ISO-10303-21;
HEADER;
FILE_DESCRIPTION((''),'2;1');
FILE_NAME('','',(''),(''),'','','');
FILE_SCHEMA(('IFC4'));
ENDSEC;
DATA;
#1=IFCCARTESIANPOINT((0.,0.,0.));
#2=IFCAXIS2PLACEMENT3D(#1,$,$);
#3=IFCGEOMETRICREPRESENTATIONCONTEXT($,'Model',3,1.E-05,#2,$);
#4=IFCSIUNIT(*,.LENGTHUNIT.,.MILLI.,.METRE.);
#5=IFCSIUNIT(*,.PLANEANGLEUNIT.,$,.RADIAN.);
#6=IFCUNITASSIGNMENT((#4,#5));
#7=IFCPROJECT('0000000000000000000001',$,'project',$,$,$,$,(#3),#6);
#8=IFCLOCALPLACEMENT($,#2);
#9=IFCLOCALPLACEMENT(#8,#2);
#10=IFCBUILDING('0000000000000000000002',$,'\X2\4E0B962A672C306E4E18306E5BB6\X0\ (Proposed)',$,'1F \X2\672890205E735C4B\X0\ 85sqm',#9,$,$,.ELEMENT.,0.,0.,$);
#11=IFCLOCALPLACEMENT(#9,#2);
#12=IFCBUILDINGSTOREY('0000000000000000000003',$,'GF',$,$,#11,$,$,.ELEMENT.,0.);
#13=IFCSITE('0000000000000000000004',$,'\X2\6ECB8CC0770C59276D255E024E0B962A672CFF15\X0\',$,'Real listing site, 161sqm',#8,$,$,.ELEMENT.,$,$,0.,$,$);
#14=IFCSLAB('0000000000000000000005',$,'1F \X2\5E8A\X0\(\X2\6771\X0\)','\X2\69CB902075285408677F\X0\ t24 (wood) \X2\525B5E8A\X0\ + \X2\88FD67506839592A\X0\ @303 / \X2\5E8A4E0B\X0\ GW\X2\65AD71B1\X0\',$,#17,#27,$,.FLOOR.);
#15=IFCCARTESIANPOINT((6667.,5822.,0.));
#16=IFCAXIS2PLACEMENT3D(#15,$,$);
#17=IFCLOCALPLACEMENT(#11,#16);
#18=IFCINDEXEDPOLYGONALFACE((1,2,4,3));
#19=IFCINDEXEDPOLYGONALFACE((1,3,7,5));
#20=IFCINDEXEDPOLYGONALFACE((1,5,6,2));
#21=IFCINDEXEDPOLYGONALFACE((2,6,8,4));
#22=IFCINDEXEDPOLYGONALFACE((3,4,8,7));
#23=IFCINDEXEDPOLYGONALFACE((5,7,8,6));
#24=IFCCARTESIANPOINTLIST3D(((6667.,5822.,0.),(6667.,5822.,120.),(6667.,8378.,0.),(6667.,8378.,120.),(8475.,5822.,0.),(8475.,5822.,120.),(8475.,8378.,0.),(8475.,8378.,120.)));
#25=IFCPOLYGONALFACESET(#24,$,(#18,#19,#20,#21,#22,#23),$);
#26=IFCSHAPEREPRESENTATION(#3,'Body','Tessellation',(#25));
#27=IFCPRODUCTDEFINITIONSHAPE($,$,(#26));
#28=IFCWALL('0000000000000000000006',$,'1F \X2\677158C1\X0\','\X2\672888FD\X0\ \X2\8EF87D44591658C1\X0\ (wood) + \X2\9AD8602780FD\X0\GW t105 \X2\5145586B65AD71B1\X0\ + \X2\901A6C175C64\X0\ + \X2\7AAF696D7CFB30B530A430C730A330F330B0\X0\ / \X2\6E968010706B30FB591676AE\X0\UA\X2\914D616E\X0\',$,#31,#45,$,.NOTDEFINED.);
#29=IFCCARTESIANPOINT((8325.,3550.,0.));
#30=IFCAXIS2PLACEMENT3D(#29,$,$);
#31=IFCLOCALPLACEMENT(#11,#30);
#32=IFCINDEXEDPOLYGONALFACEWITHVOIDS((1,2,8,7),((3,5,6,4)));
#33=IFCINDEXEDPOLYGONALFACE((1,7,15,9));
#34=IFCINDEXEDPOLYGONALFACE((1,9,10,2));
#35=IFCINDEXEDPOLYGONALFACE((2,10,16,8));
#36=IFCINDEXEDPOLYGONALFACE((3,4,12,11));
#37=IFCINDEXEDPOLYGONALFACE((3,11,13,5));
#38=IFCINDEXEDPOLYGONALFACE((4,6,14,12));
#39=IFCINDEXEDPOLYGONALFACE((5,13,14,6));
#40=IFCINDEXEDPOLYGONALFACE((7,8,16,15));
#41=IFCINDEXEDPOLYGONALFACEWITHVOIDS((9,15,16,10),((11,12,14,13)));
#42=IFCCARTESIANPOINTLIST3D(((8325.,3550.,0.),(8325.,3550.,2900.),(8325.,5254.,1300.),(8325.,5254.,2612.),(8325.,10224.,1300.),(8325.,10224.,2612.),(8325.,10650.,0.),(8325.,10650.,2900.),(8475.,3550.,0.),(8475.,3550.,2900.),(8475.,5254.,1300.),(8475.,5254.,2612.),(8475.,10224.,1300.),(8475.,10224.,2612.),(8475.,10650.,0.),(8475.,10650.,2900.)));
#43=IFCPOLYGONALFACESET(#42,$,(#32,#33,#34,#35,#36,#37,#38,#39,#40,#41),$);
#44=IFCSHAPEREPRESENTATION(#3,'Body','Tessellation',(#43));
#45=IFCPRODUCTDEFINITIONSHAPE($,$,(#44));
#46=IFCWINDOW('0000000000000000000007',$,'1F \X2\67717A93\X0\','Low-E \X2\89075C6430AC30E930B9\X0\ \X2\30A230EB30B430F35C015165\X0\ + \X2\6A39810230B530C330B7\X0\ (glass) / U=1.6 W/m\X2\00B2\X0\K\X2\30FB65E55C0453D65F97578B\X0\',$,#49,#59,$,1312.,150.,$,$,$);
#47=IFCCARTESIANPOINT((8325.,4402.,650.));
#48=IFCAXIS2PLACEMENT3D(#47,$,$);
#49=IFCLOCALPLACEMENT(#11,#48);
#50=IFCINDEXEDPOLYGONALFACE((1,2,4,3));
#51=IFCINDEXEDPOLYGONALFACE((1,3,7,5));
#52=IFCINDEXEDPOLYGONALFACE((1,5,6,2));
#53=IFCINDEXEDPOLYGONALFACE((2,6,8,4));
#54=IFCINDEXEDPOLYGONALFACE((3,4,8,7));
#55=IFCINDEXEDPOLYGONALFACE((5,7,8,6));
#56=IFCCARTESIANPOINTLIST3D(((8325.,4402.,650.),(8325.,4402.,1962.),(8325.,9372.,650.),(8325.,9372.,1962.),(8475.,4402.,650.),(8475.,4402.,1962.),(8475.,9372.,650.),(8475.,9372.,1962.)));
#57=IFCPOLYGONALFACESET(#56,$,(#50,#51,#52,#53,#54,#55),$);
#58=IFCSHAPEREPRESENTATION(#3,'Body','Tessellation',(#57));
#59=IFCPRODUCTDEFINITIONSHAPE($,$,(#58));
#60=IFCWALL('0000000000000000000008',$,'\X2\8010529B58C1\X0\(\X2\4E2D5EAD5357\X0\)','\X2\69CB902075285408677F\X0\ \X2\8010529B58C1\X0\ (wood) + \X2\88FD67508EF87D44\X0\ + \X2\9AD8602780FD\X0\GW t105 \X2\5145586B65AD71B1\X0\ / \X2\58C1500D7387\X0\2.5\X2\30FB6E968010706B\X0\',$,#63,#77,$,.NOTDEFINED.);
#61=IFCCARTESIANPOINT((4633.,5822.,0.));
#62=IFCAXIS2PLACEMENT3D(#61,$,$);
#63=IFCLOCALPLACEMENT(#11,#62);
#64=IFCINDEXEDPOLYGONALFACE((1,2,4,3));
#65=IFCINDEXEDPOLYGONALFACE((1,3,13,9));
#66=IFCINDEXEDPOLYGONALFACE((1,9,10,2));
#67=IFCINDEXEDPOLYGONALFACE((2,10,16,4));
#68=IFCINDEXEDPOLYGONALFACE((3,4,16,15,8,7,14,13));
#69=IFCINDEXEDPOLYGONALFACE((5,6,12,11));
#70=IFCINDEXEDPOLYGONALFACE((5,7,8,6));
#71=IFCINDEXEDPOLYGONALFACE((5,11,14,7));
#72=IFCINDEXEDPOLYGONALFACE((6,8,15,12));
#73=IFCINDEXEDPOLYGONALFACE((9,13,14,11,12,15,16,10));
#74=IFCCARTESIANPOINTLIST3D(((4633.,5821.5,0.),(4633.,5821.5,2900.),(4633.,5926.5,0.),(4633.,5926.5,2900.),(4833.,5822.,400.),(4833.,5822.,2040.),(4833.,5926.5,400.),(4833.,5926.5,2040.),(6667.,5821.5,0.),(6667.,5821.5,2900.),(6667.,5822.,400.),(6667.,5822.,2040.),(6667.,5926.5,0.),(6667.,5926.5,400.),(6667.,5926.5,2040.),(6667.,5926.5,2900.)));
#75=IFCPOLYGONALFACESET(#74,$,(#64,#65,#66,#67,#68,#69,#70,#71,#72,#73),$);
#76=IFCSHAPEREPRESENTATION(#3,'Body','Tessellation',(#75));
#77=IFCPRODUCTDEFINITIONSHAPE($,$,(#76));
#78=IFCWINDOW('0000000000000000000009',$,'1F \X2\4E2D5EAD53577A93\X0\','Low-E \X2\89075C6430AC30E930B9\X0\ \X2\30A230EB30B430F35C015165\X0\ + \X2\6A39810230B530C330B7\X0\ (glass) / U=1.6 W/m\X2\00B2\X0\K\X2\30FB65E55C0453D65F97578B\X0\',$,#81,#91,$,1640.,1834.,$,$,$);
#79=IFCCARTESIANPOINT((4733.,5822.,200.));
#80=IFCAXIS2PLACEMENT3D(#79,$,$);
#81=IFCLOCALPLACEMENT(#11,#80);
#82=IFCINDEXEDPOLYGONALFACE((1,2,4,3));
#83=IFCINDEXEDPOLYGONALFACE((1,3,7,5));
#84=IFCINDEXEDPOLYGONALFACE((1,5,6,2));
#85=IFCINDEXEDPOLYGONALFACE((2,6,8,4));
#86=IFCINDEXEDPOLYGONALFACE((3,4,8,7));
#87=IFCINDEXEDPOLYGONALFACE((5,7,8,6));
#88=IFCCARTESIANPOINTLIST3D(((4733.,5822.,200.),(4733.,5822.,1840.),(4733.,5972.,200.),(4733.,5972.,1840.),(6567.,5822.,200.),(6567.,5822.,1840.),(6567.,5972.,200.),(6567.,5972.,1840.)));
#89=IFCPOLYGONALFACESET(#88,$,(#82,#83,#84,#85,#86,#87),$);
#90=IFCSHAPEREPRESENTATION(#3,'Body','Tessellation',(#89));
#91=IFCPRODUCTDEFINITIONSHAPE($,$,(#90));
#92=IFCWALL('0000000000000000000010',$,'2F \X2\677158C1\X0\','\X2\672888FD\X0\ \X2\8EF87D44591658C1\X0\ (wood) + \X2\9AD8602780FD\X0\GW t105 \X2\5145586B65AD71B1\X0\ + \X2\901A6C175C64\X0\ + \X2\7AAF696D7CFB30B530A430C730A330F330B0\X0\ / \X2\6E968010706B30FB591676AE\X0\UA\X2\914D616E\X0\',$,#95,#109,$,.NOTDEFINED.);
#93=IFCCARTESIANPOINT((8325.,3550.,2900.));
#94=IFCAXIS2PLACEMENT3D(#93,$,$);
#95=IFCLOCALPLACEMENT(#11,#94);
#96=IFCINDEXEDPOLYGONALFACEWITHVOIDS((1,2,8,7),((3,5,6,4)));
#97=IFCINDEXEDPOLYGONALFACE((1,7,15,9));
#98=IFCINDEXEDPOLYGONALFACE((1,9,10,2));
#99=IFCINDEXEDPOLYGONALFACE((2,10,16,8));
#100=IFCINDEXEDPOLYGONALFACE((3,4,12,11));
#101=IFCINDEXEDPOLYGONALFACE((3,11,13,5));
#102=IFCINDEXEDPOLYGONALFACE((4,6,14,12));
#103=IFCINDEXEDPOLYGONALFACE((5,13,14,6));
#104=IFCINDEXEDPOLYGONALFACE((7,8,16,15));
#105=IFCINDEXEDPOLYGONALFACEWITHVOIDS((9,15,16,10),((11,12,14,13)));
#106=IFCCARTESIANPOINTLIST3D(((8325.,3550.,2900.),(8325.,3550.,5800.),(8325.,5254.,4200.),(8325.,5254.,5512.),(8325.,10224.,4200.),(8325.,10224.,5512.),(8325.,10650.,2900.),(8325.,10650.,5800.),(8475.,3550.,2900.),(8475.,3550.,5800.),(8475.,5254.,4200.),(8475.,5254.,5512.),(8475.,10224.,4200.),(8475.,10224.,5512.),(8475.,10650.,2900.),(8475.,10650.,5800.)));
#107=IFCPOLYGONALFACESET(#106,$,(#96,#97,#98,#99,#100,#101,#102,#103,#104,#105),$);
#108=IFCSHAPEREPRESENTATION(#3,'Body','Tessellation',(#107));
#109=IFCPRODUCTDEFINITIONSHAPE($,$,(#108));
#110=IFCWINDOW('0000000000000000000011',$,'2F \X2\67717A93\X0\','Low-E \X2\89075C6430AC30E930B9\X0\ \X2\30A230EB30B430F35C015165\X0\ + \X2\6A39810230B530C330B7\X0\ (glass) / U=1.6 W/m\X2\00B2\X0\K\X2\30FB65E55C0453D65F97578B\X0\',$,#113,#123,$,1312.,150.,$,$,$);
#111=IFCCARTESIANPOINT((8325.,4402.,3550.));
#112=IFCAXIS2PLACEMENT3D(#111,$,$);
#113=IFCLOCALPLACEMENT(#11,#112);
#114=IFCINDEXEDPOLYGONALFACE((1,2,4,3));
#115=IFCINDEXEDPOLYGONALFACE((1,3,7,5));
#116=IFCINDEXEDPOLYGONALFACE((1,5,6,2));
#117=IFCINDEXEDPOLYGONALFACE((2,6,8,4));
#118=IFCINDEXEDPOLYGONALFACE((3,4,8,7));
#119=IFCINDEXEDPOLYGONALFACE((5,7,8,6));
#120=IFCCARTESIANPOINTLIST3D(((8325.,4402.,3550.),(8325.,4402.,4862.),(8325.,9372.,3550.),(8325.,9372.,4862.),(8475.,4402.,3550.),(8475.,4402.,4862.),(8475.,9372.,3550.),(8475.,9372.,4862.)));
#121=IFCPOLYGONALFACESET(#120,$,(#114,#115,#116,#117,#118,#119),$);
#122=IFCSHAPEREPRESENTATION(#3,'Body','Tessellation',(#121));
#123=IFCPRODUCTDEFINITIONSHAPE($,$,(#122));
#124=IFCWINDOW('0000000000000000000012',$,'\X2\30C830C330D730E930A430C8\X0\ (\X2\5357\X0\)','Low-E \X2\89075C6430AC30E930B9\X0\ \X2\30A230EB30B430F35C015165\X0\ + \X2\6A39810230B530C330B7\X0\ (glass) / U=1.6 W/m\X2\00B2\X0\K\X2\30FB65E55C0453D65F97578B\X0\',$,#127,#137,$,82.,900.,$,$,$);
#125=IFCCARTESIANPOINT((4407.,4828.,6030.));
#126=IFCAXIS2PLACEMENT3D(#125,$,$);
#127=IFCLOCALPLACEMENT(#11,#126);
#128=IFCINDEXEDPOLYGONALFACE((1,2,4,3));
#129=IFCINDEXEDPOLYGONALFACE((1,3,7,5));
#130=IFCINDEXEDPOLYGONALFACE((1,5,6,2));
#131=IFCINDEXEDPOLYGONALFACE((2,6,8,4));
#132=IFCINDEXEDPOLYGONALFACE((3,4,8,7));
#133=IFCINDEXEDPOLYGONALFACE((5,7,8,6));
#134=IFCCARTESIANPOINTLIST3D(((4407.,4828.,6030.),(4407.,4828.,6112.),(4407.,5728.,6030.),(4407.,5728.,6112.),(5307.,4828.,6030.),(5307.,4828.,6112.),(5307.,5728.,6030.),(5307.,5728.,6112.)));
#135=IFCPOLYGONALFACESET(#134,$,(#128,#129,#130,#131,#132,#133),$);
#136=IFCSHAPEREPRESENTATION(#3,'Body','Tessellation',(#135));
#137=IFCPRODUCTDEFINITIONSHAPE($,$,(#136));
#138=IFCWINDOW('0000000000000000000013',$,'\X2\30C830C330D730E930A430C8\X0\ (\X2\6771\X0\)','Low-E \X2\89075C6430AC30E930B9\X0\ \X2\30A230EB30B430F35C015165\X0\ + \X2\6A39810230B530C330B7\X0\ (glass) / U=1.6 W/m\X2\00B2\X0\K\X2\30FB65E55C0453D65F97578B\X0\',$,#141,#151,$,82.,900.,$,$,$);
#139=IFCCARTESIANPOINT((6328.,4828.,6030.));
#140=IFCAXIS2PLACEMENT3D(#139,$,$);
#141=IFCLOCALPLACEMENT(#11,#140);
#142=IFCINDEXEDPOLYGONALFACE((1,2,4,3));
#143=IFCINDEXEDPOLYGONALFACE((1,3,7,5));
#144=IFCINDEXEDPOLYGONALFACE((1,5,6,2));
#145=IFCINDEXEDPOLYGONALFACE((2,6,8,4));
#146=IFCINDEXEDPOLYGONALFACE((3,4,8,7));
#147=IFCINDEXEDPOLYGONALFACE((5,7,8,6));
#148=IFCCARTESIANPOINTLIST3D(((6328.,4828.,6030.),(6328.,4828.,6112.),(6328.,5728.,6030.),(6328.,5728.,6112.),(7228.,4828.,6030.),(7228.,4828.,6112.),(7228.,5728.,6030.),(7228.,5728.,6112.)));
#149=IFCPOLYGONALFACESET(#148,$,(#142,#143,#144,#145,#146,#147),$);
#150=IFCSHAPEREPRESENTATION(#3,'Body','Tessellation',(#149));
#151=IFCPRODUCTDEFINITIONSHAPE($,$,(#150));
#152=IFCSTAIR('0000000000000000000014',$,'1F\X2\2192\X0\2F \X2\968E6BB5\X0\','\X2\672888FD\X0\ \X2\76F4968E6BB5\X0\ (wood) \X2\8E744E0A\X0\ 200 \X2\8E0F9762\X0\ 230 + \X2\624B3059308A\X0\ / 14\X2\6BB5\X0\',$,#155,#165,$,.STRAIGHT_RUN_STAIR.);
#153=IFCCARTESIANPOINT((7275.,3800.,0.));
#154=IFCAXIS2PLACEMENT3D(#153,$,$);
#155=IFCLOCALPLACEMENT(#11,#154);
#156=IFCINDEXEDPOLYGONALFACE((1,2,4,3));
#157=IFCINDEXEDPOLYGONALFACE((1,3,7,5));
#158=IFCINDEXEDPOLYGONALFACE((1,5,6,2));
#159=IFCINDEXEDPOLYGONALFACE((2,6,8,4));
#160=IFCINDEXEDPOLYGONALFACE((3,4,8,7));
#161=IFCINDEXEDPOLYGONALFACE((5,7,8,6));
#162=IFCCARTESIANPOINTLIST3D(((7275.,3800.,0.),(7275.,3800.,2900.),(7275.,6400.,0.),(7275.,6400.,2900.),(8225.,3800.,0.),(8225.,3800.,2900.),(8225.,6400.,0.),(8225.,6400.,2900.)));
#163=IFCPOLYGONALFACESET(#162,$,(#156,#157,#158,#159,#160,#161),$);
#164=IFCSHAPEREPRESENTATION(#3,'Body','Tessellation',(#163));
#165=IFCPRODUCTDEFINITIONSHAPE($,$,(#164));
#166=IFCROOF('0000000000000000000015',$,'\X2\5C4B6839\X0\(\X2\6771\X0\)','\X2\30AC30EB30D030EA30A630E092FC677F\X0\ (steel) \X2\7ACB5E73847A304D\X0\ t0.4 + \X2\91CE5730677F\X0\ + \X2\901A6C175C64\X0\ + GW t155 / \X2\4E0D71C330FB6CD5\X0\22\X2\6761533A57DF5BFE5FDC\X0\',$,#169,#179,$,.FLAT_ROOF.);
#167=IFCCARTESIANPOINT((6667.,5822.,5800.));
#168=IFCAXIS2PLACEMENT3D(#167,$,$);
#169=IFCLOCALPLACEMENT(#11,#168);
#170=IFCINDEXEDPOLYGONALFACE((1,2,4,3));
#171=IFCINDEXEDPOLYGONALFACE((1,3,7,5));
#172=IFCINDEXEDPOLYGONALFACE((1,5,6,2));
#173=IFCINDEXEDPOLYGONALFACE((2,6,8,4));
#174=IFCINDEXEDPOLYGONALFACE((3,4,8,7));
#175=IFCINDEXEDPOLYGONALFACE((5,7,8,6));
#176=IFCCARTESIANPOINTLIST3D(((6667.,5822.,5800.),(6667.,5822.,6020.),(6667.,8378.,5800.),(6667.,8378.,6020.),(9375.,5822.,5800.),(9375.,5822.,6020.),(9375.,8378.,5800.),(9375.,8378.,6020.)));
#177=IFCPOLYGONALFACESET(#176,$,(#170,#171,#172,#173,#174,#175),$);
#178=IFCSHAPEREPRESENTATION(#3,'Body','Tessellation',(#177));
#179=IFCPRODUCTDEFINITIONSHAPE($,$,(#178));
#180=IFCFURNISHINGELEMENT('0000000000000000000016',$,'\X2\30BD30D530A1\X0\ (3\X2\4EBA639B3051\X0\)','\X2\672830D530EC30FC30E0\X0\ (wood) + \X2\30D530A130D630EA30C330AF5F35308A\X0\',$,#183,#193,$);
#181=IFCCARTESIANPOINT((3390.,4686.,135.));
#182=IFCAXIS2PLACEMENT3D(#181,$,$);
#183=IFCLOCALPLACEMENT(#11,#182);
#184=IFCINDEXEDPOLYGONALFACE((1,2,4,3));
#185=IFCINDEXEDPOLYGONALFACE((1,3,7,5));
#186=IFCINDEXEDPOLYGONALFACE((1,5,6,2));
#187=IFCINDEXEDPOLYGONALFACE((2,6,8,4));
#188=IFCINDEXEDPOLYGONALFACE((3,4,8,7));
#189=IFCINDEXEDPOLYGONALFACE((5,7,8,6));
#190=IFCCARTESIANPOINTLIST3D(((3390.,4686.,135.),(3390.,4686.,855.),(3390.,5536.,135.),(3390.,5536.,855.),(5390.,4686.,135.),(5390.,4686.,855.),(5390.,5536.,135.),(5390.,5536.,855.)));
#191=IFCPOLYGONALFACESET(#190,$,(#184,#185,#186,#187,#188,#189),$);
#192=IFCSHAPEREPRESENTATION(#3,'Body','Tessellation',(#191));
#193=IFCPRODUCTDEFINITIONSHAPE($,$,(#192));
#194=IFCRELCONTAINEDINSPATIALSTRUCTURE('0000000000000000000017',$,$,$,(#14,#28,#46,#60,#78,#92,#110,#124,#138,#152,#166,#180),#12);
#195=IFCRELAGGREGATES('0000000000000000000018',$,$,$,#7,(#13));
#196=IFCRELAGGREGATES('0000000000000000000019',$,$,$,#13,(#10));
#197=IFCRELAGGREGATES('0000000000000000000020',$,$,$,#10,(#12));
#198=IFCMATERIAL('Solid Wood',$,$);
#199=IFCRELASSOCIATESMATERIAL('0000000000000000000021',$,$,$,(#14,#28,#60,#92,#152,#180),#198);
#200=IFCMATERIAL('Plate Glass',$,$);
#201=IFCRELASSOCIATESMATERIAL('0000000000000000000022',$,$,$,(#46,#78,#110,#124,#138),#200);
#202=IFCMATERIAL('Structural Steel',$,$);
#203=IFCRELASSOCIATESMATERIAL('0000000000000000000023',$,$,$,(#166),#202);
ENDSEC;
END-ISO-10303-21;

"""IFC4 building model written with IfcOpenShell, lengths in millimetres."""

from ifc_helpers import new_model, si_unit, frame, frame_2d, origin, place, context, project, spatial, rectangle, extrude, material, element, fill, save


model = new_model("IFC4")

# Units and contexts
model_context = context("Model", 3, precision=1e-05, world=origin())
ifc_project = project(units=[si_unit("LENGTHUNIT", "METRE", prefix="MILLI"), si_unit("PLANEANGLEUNIT", "RADIAN")], contexts=[model_context])

# Site, building, storey
site_placement = place(None, origin())
site = spatial("IfcSite", under=ifc_project, at=site_placement, Name="滋賀県大津市下阪本５", ObjectType="Real listing site, 161sqm", CompositionType="ELEMENT", RefElevation=0.0)
building_placement = place(site_placement, origin())
building = spatial("IfcBuilding", under=site, at=building_placement, Name="下阪本の丘の家 (Proposed)", ObjectType="1F 木造平屋 85sqm", CompositionType="ELEMENT", ElevationOfRefHeight=0.0, ElevationOfTerrain=0.0)
storey_placement = place(building_placement, origin())
storey = spatial("IfcBuildingStorey", under=building, at=storey_placement, Name="GF", CompositionType="ELEMENT", Elevation=0.0)

# Slab
ifc_material_1 = material(Name="Solid Wood")
slab_placement = place(storey_placement, frame((6667.0, 5822.0, 0.0)))
element("IfcSlab", 1, at=slab_placement, inside=storey, material=ifc_material_1, Name="1F 床(東)", Description="構造用合板 t24 (wood) 剛床 + 製材根太 @303 / 床下 GW断熱", PredefinedType="FLOOR", context=model_context, shape_type="SweptSolid", body=[
    extrude(rectangle(XDim=1808.0, YDim=2556.0, at=frame_2d((904.0, 1278.0))), frame((6667.0, 5822.0, 0.0)), (0.0, 0.0, 1.0), 120.0),
])

# Walls, openings, windows
wall_1_placement = place(storey_placement, frame((8325.0, 3550.0, 0.0)))
wall_1 = element("IfcWall", 2, at=wall_1_placement, inside=storey, material=ifc_material_1, Name="1F 東壁", Description="木製 軸組外壁 (wood) + 高性能GW t105 充填断熱 + 通気層 + 窯業系サイディング / 準耐火・外皮UA配慮", PredefinedType="NOTDEFINED", context=model_context, shape_type="SweptSolid", body=[
    extrude(rectangle(XDim=150.0, YDim=7100.0, at=frame_2d((75.0, 3550.0))), frame((8325.0, 3550.0, 0.0)), (0.0, 0.0, 1.0), 2900.0),
])
opening_1_placement = place(storey_placement, frame((8325.0, 4402.0, 650.0)))
opening_1 = element("IfcOpeningElement", 3, at=opening_1_placement, cuts=wall_1, PredefinedType="NOTDEFINED", context=model_context, shape_type="SweptSolid", body=[
    extrude(rectangle(XDim=150.0, YDim=4970.0, at=frame_2d((75.0, 2485.0))), frame((8325.0, 4402.0, 650.0)), (0.0, 0.0, 1.0), 1312.0),
])
ifc_material_2 = material(Name="Plate Glass")
window_1_placement = place(storey_placement, frame((8325.0, 4402.0, 650.0)))
window_1 = element("IfcWindow", 4, at=window_1_placement, inside=storey, material=ifc_material_2, Name="1F 東窓", Description="Low-E 複層ガラス アルゴン封入 + 樹脂サッシ (glass) / U=1.6 W/m²K・日射取得型", OverallHeight=1312.0, OverallWidth=150.0, context=model_context, shape_type="SweptSolid", body=[
    extrude(rectangle(XDim=150.0, YDim=4970.0, at=frame_2d((75.0, 2485.0))), frame((8325.0, 4402.0, 650.0)), (0.0, 0.0, 1.0), 1312.0),
])
fill(opening_1, window_1)
wall_2_placement = place(storey_placement, frame((4633.0, 5822.0, 0.0)))
wall_2 = element("IfcWall", 5, at=wall_2_placement, inside=storey, material=ifc_material_1, Name="耐力壁(中庭南)", Description="構造用合板 耐力壁 (wood) + 製材軸組 + 高性能GW t105 充填断熱 / 壁倍率2.5・準耐火", PredefinedType="NOTDEFINED", context=model_context, shape_type="SweptSolid", body=[
    extrude(rectangle(XDim=2034.0, YDim=105.0, at=frame_2d((1017.0, 52.0))), frame((4633.0, 5822.0, 0.0)), (0.0, 0.0, 1.0), 2900.0),
])
opening_2_placement = place(storey_placement, frame((4733.0, 5822.0, 200.0)))
opening_2 = element("IfcOpeningElement", 6, at=opening_2_placement, cuts=wall_2, PredefinedType="NOTDEFINED", context=model_context, shape_type="SweptSolid", body=[
    extrude(rectangle(XDim=1834.0, YDim=150.0, at=frame_2d((917.0, 75.0))), frame((4733.0, 5822.0, 200.0)), (0.0, 0.0, 1.0), 1640.0),
])
window_2_placement = place(storey_placement, frame((4733.0, 5822.0, 200.0)))
window_2 = element("IfcWindow", 7, at=window_2_placement, inside=storey, material=ifc_material_2, Name="1F 中庭南窓", Description="Low-E 複層ガラス アルゴン封入 + 樹脂サッシ (glass) / U=1.6 W/m²K・日射取得型", OverallHeight=1640.0, OverallWidth=1834.0, context=model_context, shape_type="SweptSolid", body=[
    extrude(rectangle(XDim=1834.0, YDim=150.0, at=frame_2d((917.0, 75.0))), frame((4733.0, 5822.0, 200.0)), (0.0, 0.0, 1.0), 1640.0),
])
fill(opening_2, window_2)

# Wall, opening, window
wall_3_placement = place(storey_placement, frame((8325.0, 3550.0, 2900.0)))
wall_3 = element("IfcWall", 8, at=wall_3_placement, inside=storey, material=ifc_material_1, Name="2F 東壁", Description="木製 軸組外壁 (wood) + 高性能GW t105 充填断熱 + 通気層 + 窯業系サイディング / 準耐火・外皮UA配慮", PredefinedType="NOTDEFINED", context=model_context, shape_type="SweptSolid", body=[
    extrude(rectangle(XDim=150.0, YDim=7100.0, at=frame_2d((75.0, 3550.0))), frame((8325.0, 3550.0, 2900.0)), (0.0, 0.0, 1.0), 2900.0),
])
opening_3_placement = place(storey_placement, frame((8325.0, 4402.0, 3550.0)))
opening_3 = element("IfcOpeningElement", 9, at=opening_3_placement, cuts=wall_3, PredefinedType="NOTDEFINED", context=model_context, shape_type="SweptSolid", body=[
    extrude(rectangle(XDim=150.0, YDim=4970.0, at=frame_2d((75.0, 2485.0))), frame((8325.0, 4402.0, 3550.0)), (0.0, 0.0, 1.0), 1312.0),
])
window_3_placement = place(storey_placement, frame((8325.0, 4402.0, 3550.0)))
window_3 = element("IfcWindow", 10, at=window_3_placement, inside=storey, material=ifc_material_2, Name="2F 東窓", Description="Low-E 複層ガラス アルゴン封入 + 樹脂サッシ (glass) / U=1.6 W/m²K・日射取得型", OverallHeight=1312.0, OverallWidth=150.0, context=model_context, shape_type="SweptSolid", body=[
    extrude(rectangle(XDim=150.0, YDim=4970.0, at=frame_2d((75.0, 2485.0))), frame((8325.0, 4402.0, 3550.0)), (0.0, 0.0, 1.0), 1312.0),
])
fill(opening_3, window_3)

# Windows
window_4_placement = place(storey_placement, frame((4407.0, 4828.0, 6030.0)))
element("IfcWindow", 11, at=window_4_placement, inside=storey, material=ifc_material_2, Name="トップライト (南)", Description="Low-E 複層ガラス アルゴン封入 + 樹脂サッシ (glass) / U=1.6 W/m²K・日射取得型", OverallHeight=82.0, OverallWidth=900.0, context=model_context, shape_type="SweptSolid", body=[
    extrude(rectangle(XDim=900.0, YDim=900.0, at=frame_2d((450.0, 450.0))), frame((4407.0, 4828.0, 6030.0)), (0.0, 0.0, 1.0), 82.0),
])
window_5_placement = place(storey_placement, frame((6328.0, 4828.0, 6030.0)))
element("IfcWindow", 12, at=window_5_placement, inside=storey, material=ifc_material_2, Name="トップライト (東)", Description="Low-E 複層ガラス アルゴン封入 + 樹脂サッシ (glass) / U=1.6 W/m²K・日射取得型", OverallHeight=82.0, OverallWidth=900.0, context=model_context, shape_type="SweptSolid", body=[
    extrude(rectangle(XDim=900.0, YDim=900.0, at=frame_2d((450.0, 450.0))), frame((6328.0, 4828.0, 6030.0)), (0.0, 0.0, 1.0), 82.0),
])

# Stair
stair_placement = place(storey_placement, frame((7275.0, 3800.0, 0.0)))
element("IfcStair", 13, at=stair_placement, inside=storey, material=ifc_material_1, Name="1F→2F 階段", Description="木製 直階段 (wood) 蹴上 200 踏面 230 + 手すり / 14段", PredefinedType="STRAIGHT_RUN_STAIR", context=model_context, shape_type="SweptSolid", body=[
    extrude(rectangle(XDim=950.0, YDim=2600.0, at=frame_2d((475.0, 1300.0))), frame((7275.0, 3800.0, 0.0)), (0.0, 0.0, 1.0), 2900.0),
])

# Roof
ifc_material_3 = material(Name="Structural Steel")
roof_placement = place(storey_placement, frame((6667.0, 5822.0, 5800.0)))
element("IfcRoof", 14, at=roof_placement, inside=storey, material=ifc_material_3, Name="屋根(東)", Description="ガルバリウム鋼板 (steel) 立平葺き t0.4 + 野地板 + 通気層 + GW t155 / 不燃・法22条区域対応", PredefinedType="FLAT_ROOF", context=model_context, shape_type="SweptSolid", body=[
    extrude(rectangle(XDim=2708.0, YDim=2556.0, at=frame_2d((1354.0, 1278.0))), frame((6667.0, 5822.0, 5800.0)), (0.0, 0.0, 1.0), 220.0),
])

# Furnishing element
furnishing_1_placement = place(storey_placement, frame((3390.0, 4686.0, 135.0)))
element("IfcFurnishingElement", 15, at=furnishing_1_placement, inside=storey, material=ifc_material_1, Name="ソファ (3人掛け)", Description="木フレーム (wood) + ファブリック張り", context=model_context, shape_type="SweptSolid", body=[
    extrude(rectangle(XDim=2000.0, YDim=850.0, at=frame_2d((1000.0, 425.0))), frame((3390.0, 4686.0, 135.0)), (0.0, 0.0, 1.0), 720.0),
])

save(model, "model.ifc")
